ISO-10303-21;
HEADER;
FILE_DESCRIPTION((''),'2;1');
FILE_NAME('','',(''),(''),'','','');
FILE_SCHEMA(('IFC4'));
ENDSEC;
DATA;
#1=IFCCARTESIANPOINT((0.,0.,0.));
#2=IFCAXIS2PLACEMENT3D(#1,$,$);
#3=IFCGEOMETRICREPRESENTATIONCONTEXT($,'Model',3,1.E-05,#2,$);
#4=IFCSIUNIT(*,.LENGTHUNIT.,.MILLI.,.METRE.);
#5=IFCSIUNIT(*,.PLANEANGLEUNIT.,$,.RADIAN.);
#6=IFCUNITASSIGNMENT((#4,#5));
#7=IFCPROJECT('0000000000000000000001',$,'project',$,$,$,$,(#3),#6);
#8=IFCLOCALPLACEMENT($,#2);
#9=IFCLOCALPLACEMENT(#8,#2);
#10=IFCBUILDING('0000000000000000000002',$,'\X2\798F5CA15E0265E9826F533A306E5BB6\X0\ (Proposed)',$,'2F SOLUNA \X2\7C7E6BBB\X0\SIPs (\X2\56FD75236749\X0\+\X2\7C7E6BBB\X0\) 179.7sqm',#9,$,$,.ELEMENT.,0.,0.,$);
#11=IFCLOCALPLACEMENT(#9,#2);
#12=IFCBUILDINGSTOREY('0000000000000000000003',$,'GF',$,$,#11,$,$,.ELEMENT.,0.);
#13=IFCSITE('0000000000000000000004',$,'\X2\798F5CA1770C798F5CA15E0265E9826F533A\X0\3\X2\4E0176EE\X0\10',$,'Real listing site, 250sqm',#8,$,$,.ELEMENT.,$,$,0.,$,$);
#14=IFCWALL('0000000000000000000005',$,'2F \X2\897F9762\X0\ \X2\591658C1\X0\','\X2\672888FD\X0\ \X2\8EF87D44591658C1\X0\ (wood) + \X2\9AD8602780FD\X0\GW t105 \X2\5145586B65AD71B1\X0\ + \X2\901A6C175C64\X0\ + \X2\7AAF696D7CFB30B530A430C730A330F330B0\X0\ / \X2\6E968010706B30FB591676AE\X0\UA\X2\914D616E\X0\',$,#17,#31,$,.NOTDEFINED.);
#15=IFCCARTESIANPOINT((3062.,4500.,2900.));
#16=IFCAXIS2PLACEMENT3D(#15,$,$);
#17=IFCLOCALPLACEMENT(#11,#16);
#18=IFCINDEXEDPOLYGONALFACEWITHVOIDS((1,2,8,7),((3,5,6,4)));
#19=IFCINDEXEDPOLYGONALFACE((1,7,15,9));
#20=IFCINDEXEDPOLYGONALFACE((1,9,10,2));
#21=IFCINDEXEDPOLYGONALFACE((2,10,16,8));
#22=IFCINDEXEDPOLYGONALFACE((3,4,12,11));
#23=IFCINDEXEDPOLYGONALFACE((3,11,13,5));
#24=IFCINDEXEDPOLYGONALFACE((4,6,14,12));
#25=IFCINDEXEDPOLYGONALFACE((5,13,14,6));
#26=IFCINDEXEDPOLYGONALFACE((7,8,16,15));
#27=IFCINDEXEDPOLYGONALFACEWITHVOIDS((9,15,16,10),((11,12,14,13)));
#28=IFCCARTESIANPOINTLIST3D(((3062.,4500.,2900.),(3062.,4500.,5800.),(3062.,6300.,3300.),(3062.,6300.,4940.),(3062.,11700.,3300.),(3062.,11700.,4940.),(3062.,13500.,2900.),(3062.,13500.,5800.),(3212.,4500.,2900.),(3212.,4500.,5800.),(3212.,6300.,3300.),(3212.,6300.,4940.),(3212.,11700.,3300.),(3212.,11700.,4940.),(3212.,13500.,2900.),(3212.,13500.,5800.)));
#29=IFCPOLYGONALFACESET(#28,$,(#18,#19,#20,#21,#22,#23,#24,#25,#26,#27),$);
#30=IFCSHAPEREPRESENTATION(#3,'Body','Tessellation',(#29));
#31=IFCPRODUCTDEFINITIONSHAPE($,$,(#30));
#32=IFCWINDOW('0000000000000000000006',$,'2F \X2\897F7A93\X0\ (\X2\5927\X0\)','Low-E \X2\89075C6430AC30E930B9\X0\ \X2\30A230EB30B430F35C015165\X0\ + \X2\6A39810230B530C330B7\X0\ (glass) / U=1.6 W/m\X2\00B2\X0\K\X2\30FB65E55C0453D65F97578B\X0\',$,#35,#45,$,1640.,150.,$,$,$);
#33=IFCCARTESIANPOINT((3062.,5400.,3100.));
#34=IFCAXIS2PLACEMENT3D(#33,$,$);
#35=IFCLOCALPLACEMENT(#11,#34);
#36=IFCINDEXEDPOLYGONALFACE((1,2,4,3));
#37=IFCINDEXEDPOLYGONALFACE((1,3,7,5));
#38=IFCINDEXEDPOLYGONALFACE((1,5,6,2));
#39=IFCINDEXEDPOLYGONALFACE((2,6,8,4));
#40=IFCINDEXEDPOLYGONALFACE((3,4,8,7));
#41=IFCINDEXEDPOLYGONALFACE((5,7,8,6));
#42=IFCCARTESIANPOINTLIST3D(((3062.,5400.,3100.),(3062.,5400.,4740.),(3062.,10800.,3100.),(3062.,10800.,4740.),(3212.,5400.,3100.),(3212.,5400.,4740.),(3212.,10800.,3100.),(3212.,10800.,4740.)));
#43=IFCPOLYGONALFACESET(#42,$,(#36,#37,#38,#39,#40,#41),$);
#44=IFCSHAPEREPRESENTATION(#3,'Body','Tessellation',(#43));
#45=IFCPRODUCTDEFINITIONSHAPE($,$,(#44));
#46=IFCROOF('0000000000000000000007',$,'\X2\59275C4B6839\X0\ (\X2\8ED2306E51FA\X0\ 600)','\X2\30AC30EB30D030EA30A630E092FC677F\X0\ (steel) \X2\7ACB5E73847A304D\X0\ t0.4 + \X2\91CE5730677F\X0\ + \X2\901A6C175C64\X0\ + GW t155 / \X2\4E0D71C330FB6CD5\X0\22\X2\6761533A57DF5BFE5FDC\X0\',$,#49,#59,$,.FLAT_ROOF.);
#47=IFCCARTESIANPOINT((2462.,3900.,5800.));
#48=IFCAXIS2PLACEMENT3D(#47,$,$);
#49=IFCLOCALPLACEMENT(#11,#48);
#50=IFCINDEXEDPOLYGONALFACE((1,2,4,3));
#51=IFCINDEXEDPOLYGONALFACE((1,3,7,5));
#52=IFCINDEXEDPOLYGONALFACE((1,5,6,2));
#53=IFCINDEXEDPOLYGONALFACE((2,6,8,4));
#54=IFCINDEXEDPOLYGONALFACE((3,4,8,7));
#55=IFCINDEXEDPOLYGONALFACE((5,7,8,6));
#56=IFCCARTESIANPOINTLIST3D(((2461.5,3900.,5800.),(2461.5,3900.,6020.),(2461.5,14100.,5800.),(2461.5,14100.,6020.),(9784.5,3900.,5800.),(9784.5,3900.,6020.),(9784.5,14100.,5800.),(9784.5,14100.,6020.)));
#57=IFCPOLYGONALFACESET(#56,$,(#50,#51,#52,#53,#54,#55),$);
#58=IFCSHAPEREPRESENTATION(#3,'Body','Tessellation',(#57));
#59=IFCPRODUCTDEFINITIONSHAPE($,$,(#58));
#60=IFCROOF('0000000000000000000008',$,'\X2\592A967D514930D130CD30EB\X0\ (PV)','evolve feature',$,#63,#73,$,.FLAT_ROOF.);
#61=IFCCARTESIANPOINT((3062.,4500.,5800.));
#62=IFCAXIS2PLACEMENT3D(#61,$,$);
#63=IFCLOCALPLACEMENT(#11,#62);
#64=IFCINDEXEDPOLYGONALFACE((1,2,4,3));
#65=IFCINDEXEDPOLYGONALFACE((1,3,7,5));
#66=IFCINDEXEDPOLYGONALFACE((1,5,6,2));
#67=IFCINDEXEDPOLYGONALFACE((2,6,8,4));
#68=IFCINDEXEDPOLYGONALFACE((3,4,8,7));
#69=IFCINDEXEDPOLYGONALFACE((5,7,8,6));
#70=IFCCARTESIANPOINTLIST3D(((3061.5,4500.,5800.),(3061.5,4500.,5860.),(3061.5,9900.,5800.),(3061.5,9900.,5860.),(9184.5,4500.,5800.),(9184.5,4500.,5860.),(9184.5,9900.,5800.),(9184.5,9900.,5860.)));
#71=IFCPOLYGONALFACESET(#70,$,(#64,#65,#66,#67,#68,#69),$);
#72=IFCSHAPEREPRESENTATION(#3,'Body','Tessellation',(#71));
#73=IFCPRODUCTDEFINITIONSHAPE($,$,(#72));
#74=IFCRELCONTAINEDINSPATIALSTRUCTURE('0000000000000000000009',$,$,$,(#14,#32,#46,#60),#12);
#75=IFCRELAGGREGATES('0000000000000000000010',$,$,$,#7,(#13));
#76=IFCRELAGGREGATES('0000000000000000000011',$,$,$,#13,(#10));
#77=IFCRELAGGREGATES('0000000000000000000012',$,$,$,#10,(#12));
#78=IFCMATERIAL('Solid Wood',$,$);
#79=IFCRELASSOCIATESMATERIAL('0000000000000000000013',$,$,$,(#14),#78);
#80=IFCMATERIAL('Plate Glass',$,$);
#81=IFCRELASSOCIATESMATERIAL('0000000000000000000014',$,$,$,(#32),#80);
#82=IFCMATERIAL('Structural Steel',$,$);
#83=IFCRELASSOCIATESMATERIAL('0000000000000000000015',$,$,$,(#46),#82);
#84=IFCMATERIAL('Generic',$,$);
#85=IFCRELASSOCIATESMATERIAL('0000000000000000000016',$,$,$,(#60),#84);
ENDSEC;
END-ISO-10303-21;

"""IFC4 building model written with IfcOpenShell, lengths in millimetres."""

from ifc_helpers import new_model, si_unit, frame, frame_2d, origin, place, context, project, spatial, rectangle, extrude, material, element, fill, save


model = new_model("IFC4")

# Units and contexts
model_context = context("Model", 3, precision=1e-05, world=origin())
ifc_project = project(units=[si_unit("LENGTHUNIT", "METRE", prefix="MILLI"), si_unit("PLANEANGLEUNIT", "RADIAN")], contexts=[model_context])

# Site, building, storey
site_placement = place(None, origin())
site = spatial("IfcSite", under=ifc_project, at=site_placement, Name="福岡県福岡市早良区3丁目10", ObjectType="Real listing site, 250sqm", CompositionType="ELEMENT", RefElevation=0.0)
building_placement = place(site_placement, origin())
building = spatial("IfcBuilding", under=site, at=building_placement, Name="福岡市早良区の家 (Proposed)", ObjectType="2F SOLUNA 籾殻SIPs (国産杉+籾殻) 179.7sqm", CompositionType="ELEMENT", ElevationOfRefHeight=0.0, ElevationOfTerrain=0.0)
storey_placement = place(building_placement, origin())
storey = spatial("IfcBuildingStorey", under=building, at=storey_placement, Name="GF", CompositionType="ELEMENT", Elevation=0.0)

# Shared definitions
ifc_material_1 = material(Name="Solid Wood")
ifc_material_2 = material(Name="Generic")

# Shared definitions
ifc_material_3 = material(Name="Plate Glass")

# Wall, opening, window
wall_1_placement = place(storey_placement, frame((3062.0, 4500.0, 2900.0)))
wall_1 = element("IfcWall", 1, at=wall_1_placement, inside=storey, material=ifc_material_1, Name="2F 西面 外壁", Description="木製 軸組外壁 (wood) + 高性能GW t105 充填断熱 + 通気層 + 窯業系サイディング / 準耐火・外皮UA配慮", PredefinedType="NOTDEFINED", context=model_context, shape_type="SweptSolid", body=[
    extrude(rectangle(XDim=150.0, YDim=9000.0, at=frame_2d((75.0, 4500.0))), frame((3062.0, 4500.0, 2900.0)), (0.0, 0.0, 1.0), 2900.0),
])
opening_1_placement = place(storey_placement, frame((3062.0, 5400.0, 3100.0)))
opening_1 = element("IfcOpeningElement", 2, at=opening_1_placement, cuts=wall_1, PredefinedType="NOTDEFINED", context=model_context, shape_type="SweptSolid", body=[
    extrude(rectangle(XDim=150.0, YDim=5400.0, at=frame_2d((75.0, 2700.0))), frame((3062.0, 5400.0, 3100.0)), (0.0, 0.0, 1.0), 1640.0),
])
window_1_placement = place(storey_placement, frame((3062.0, 5400.0, 3100.0)))
window_1 = element("IfcWindow", 3, at=window_1_placement, inside=storey, material=ifc_material_3, Name="2F 西窓 (大)", Description="Low-E 複層ガラス アルゴン封入 + 樹脂サッシ (glass) / U=1.6 W/m²K・日射取得型", OverallHeight=1640.0, OverallWidth=150.0, context=model_context, shape_type="SweptSolid", body=[
    extrude(rectangle(XDim=150.0, YDim=5400.0, at=frame_2d((75.0, 2700.0))), frame((3062.0, 5400.0, 3100.0)), (0.0, 0.0, 1.0), 1640.0),
])
fill(opening_1, window_1)

# Roofs
ifc_material_4 = material(Name="Structural Steel")
roof_1_placement = place(storey_placement, frame((2462.0, 3900.0, 5800.0)))
element("IfcRoof", 4, at=roof_1_placement, inside=storey, material=ifc_material_4, Name="大屋根 (軒の出 600)", Description="ガルバリウム鋼板 (steel) 立平葺き t0.4 + 野地板 + 通気層 + GW t155 / 不燃・法22条区域対応", PredefinedType="FLAT_ROOF", context=model_context, shape_type="SweptSolid", body=[
    extrude(rectangle(XDim=7323.0, YDim=10200.0, at=frame_2d((3661.0, 5100.0))), frame((2462.0, 3900.0, 5800.0)), (0.0, 0.0, 1.0), 220.0),
])
roof_2_placement = place(storey_placement, frame((3062.0, 4500.0, 5800.0)))
element("IfcRoof", 5, at=roof_2_placement, inside=storey, material=ifc_material_2, Name="太陽光パネル (PV)", Description="evolve feature", PredefinedType="FLAT_ROOF", context=model_context, shape_type="SweptSolid", body=[
    extrude(rectangle(XDim=6123.0, YDim=5400.0, at=frame_2d((3061.0, 2700.0))), frame((3062.0, 4500.0, 5800.0)), (0.0, 0.0, 1.0), 60.0),
])

save(model, "model.ifc")
